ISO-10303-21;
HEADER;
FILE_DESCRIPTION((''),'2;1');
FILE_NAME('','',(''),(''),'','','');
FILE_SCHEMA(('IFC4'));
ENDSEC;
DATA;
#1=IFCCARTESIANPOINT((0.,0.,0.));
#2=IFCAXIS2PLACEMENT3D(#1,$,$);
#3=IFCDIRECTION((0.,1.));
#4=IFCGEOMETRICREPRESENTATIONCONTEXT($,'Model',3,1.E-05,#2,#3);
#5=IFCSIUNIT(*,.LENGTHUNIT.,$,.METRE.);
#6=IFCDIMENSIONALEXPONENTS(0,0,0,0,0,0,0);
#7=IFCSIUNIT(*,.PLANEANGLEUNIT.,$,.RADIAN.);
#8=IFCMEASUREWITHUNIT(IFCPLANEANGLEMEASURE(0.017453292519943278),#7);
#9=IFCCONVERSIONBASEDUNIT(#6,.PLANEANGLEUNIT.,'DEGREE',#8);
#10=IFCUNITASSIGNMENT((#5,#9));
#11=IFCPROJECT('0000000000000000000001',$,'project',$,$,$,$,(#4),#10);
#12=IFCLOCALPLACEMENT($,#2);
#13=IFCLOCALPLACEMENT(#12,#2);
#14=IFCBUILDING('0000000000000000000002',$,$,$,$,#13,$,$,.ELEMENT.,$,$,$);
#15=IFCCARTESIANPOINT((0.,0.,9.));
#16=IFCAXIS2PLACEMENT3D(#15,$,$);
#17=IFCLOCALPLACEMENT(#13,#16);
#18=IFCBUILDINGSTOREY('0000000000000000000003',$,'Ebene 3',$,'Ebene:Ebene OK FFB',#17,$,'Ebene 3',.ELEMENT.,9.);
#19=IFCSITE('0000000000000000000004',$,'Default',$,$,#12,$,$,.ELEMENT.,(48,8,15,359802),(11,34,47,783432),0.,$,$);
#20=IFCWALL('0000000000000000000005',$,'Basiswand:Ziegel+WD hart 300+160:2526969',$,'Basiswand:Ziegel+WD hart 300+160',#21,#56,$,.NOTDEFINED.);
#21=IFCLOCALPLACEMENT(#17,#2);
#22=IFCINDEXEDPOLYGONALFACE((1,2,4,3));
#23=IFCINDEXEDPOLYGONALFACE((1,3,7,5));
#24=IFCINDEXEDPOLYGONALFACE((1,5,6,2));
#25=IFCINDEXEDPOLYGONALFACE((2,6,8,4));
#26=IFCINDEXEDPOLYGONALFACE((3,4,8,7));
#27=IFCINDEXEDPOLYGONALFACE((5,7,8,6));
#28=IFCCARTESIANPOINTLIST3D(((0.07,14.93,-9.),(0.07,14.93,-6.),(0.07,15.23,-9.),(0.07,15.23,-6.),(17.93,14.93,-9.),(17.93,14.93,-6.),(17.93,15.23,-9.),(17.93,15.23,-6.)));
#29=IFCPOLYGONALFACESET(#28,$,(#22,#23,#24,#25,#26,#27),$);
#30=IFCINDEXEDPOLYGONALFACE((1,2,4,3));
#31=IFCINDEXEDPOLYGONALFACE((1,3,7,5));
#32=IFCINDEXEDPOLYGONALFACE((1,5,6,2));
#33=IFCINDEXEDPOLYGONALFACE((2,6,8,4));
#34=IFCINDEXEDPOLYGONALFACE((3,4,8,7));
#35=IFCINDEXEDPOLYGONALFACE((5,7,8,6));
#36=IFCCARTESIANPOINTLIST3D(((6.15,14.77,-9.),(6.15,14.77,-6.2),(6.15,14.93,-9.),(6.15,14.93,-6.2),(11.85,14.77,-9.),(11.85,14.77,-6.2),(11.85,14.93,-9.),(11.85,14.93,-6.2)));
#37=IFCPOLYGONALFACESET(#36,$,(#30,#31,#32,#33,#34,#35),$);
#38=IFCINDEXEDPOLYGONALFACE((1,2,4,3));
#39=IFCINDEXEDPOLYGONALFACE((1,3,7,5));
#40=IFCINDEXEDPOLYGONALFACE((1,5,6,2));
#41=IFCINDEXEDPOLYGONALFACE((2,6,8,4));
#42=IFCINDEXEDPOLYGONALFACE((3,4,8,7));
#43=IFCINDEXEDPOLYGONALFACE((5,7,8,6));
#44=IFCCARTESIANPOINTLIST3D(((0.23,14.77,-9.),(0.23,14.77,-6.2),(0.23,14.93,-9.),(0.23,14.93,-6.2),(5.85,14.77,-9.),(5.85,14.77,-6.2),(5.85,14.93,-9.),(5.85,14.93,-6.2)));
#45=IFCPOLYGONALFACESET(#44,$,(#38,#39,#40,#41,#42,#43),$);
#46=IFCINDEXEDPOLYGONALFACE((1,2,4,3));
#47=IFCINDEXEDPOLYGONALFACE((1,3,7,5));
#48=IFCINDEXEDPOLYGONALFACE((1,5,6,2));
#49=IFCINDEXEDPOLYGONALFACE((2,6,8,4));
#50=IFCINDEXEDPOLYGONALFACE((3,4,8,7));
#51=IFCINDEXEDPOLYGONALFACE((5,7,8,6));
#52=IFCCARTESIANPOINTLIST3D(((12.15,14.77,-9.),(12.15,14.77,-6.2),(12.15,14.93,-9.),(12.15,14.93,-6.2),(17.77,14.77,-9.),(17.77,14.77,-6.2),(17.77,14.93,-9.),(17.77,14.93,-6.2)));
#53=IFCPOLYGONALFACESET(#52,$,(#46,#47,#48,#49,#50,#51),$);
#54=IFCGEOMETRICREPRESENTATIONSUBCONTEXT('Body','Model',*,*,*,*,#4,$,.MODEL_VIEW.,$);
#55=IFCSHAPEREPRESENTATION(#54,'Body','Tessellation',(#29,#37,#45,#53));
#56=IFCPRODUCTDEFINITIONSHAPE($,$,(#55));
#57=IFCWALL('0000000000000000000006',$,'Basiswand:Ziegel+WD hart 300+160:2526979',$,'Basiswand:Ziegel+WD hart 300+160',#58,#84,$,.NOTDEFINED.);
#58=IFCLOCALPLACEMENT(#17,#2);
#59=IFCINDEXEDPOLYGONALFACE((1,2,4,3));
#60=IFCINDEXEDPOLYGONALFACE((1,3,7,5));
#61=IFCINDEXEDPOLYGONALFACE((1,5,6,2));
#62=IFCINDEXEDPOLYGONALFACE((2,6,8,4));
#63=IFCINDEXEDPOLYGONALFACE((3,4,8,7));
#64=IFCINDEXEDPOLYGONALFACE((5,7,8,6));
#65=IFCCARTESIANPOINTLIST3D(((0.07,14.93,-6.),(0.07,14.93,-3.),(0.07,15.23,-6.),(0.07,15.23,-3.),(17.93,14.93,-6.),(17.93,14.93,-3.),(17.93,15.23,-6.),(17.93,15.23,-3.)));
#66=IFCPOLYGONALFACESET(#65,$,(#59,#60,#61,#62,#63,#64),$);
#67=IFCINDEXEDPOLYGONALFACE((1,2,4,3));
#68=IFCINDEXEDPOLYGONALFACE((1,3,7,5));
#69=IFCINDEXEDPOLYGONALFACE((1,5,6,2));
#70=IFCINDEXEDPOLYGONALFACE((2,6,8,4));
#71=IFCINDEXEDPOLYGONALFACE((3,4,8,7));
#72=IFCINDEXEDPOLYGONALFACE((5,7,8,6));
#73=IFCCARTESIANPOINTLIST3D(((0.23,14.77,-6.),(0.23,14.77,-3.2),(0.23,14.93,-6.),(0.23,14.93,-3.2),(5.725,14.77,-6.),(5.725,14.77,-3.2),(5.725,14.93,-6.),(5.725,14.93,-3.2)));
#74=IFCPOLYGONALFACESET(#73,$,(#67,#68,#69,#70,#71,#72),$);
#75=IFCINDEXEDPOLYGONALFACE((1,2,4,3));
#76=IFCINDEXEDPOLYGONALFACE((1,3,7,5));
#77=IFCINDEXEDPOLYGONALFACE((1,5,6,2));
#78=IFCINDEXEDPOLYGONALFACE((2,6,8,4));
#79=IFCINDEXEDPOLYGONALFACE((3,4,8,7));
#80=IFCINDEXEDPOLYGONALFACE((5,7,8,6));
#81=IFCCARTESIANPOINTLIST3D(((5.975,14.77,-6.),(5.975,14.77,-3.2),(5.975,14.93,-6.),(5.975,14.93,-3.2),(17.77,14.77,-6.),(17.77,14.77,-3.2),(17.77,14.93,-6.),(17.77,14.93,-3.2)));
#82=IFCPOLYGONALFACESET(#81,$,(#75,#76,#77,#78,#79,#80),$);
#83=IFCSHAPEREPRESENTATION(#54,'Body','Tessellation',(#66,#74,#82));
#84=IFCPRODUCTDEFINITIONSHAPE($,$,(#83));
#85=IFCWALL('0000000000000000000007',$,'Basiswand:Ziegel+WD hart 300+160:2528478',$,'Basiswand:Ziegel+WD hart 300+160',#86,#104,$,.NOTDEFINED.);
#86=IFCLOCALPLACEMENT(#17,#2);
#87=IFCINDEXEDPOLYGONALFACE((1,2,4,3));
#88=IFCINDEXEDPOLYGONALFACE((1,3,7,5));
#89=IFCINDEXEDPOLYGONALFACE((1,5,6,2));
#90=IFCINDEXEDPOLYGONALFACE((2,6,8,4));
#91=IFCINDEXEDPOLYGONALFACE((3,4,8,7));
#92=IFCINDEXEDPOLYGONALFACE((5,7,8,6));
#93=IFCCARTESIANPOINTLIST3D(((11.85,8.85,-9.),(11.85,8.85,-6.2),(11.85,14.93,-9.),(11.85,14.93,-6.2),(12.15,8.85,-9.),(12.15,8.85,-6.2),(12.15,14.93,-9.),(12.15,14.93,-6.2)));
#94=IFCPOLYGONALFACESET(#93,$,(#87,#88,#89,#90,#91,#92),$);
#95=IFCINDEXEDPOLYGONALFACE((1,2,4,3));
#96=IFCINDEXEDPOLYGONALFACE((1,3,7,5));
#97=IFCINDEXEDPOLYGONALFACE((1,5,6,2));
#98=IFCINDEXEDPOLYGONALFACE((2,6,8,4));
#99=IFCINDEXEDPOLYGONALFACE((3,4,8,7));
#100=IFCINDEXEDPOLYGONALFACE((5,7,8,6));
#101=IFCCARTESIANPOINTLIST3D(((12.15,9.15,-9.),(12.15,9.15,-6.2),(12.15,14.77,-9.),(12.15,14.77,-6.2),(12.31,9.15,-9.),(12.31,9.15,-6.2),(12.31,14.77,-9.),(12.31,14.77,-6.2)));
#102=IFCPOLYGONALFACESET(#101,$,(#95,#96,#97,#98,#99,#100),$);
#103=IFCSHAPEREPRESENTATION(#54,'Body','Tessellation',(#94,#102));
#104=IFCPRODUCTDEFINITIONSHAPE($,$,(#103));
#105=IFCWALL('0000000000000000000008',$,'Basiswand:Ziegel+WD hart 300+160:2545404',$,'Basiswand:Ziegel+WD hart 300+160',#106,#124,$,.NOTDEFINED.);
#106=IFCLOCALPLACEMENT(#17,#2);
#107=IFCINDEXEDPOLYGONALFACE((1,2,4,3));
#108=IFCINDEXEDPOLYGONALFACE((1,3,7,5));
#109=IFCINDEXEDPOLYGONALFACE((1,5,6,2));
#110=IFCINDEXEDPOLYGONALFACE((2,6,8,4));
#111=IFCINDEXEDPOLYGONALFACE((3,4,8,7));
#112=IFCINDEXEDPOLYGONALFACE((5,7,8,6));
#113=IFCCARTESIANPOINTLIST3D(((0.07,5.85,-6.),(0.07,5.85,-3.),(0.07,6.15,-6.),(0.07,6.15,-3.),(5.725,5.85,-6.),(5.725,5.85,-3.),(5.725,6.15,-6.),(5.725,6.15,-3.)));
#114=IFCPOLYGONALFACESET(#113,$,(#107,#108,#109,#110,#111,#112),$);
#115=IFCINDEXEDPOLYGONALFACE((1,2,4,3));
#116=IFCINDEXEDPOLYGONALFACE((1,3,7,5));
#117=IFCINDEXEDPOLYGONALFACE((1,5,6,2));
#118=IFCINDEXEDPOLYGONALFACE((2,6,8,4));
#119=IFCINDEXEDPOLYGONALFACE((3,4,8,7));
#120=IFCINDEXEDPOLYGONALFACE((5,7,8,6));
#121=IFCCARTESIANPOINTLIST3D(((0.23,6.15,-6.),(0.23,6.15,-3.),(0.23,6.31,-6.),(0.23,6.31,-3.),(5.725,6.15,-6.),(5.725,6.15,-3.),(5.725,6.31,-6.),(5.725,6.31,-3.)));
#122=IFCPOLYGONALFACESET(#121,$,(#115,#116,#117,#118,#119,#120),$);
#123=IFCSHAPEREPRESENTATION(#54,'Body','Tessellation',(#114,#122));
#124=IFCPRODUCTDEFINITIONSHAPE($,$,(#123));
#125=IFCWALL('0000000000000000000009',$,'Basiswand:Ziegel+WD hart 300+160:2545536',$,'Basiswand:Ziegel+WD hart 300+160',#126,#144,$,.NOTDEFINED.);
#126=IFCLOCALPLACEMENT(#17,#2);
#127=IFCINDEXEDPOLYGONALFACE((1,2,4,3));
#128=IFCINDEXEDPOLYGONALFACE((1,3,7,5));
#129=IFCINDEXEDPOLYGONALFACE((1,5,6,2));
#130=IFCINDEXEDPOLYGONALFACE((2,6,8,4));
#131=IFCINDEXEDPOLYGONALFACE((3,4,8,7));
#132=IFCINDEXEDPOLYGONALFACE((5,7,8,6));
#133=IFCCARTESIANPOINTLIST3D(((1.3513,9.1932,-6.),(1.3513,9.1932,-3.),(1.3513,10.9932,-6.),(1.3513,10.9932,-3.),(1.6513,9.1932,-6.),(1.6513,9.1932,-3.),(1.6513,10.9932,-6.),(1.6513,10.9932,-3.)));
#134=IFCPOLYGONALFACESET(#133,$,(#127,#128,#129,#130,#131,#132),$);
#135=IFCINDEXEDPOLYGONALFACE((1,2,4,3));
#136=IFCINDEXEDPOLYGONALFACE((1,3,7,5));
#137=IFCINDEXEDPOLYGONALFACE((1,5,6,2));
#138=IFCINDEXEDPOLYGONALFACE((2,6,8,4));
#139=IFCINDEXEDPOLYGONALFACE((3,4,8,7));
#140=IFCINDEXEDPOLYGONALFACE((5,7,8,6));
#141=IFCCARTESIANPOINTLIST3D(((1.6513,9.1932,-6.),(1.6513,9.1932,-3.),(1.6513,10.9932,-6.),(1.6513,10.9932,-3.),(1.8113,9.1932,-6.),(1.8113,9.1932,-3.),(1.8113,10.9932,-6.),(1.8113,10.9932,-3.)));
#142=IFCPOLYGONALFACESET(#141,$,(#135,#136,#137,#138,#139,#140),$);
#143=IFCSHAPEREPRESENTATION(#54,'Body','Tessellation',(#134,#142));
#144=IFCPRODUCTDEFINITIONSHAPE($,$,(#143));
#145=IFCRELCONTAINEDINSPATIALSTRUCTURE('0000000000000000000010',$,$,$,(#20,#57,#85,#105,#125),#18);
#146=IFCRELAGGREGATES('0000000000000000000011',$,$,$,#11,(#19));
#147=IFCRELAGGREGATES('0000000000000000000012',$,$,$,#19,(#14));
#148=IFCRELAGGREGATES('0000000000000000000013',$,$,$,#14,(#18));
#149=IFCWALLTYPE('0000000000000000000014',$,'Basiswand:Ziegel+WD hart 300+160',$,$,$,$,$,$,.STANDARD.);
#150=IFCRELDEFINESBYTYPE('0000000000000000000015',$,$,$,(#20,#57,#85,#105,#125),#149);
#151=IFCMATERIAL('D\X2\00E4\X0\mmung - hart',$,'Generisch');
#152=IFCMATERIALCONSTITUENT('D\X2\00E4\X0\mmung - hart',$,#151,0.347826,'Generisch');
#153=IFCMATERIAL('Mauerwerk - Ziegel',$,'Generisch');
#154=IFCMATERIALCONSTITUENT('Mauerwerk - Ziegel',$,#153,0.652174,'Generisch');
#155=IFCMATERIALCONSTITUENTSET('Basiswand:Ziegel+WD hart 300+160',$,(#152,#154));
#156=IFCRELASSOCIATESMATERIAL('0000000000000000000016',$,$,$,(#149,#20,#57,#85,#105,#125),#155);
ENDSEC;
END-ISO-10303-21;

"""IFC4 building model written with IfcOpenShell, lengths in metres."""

from ifc_helpers import new_model, entity, si_unit, converted_unit, direction, frame, origin, place, context, subcontext, project, spatial, indexed_curve, outline, extrude, material, constituent, constituent_set, type_object, element, save


model = new_model("IFC4")

# Units and contexts
model_context = context("Model", 3, precision=1e-05, world=origin(), true_north=direction((0.0, 1.0)))
body_context = subcontext(model_context, "Body", "Model", "MODEL_VIEW")
ifc_project = project(units=[si_unit("LENGTHUNIT", "METRE"), converted_unit("PLANEANGLEUNIT", "DEGREE", entity("IfcPlaneAngleMeasure", 0.017453292519943278), si_unit("PLANEANGLEUNIT", "RADIAN"), dimensions=[0, 0, 0, 0, 0, 0, 0])], contexts=[model_context])

# Site, building, storey
site_placement = place(None, origin())
site = spatial("IfcSite", under=ifc_project, at=site_placement, Name="Default", CompositionType="ELEMENT", RefLatitude=(48, 8, 15, 359802), RefLongitude=(11, 34, 47, 783432), RefElevation=0.0)
building_placement = place(site_placement, origin())
building = spatial("IfcBuilding", under=site, at=building_placement, CompositionType="ELEMENT")
storey_placement = place(building_placement, frame((0.0, 0.0, 9.0)))
storey = spatial("IfcBuildingStorey", under=building, at=storey_placement, Name="Ebene 3", ObjectType="Ebene:Ebene OK FFB", LongName="Ebene 3", CompositionType="ELEMENT", Elevation=9.0)

# Walls
ifc_material_1 = material(Name="Dämmung - hart", Category="Generisch")
ifc_constituent_1 = constituent(ifc_material_1, Name="Dämmung - hart", Category="Generisch", fraction=0.347826)
ifc_material_2 = material(Name="Mauerwerk - Ziegel", Category="Generisch")
ifc_constituent_2 = constituent(ifc_material_2, Name="Mauerwerk - Ziegel", Category="Generisch", fraction=0.652174)
ifc_constituent_set_1 = constituent_set(constituents=[ifc_constituent_1, ifc_constituent_2], Name="Basiswand:Ziegel+WD hart 300+160")
wall_type_1 = type_object("IfcWallType", Name="Basiswand:Ziegel+WD hart 300+160", PredefinedType="STANDARD", material=ifc_constituent_set_1)
wall_1_placement = place(storey_placement, frame((17.77, 15.0, -9.0), z_axis=(0.0, 0.0, 1.0), x_axis=(-1.0, 0.0, 0.0)))
element("IfcWall", 1, at=wall_1_placement, inside=storey, type_object=wall_type_1, material=ifc_constituent_set_1, Name="Basiswand:Ziegel+WD hart 300+160:2526969", ObjectType="Basiswand:Ziegel+WD hart 300+160", PredefinedType="NOTDEFINED", context=body_context, shape_type="SweptSolid", body=[
    extrude(outline(indexed_curve([(-0.15, -8.93), (0.15, -8.93), (0.15, 8.93), (-0.15, 8.93), (-0.15, -8.93)], self_intersect=False)), frame((8.77, -0.08, 0.0), z_axis=(0.0, 0.0, 1.0), x_axis=(0.0, 1.0, 0.0)), (0.0, 0.0, 1.0), 3.0),
    extrude(outline(indexed_curve([(-2.85, -0.08), (2.85, -0.08), (2.85, 0.08), (-2.85, 0.08), (-2.85, -0.08)], self_intersect=False)), frame((8.77, 0.15, 0.0)), (0.0, 0.0, 1.0), 2.8),
    extrude(outline(indexed_curve([(-2.81, -0.08), (2.81, -0.08), (2.81, 0.08), (-2.81, 0.08), (-2.81, -0.08)], self_intersect=False)), frame((14.73, 0.15, 0.0), z_axis=(0.0, 0.0, 1.0), x_axis=(-1.0, 0.0, 0.0)), (0.0, 0.0, 1.0), 2.8),
    extrude(outline(indexed_curve([(-2.81, -0.08), (2.81, -0.08), (2.81, 0.08), (-2.81, 0.08), (-2.81, -0.08)], self_intersect=False)), frame((2.81, 0.15, 0.0)), (0.0, 0.0, 1.0), 2.8),
])
wall_2_placement = place(storey_placement, frame((17.77, 15.0, -6.0), z_axis=(0.0, 0.0, 1.0), x_axis=(-1.0, 0.0, 0.0)))
element("IfcWall", 2, at=wall_2_placement, inside=storey, type_object=wall_type_1, material=ifc_constituent_set_1, Name="Basiswand:Ziegel+WD hart 300+160:2526979", ObjectType="Basiswand:Ziegel+WD hart 300+160", PredefinedType="NOTDEFINED", context=body_context, shape_type="SweptSolid", body=[
    extrude(outline(indexed_curve([(-0.15, -8.93), (0.15, -8.93), (0.15, 8.93), (-0.15, 8.93), (-0.15, -8.93)], self_intersect=False)), frame((8.77, -0.08, 0.0), z_axis=(0.0, 0.0, 1.0), x_axis=(0.0, 1.0, 0.0)), (0.0, 0.0, 1.0), 3.0),
    extrude(outline(indexed_curve([(-2.7475, -0.08), (2.7475, -0.08), (2.7475, 0.08), (-2.7475, 0.08), (-2.7475, -0.08)], self_intersect=False)), frame((14.7925, 0.15, 0.0), z_axis=(0.0, 0.0, 1.0), x_axis=(-1.0, 0.0, 0.0)), (0.0, 0.0, 1.0), 2.8),
    extrude(outline(indexed_curve([(-5.8975, -0.08), (5.8975, -0.08), (5.8975, 0.08), (-5.8975, 0.08), (-5.8975, -0.08)], self_intersect=False)), frame((5.8975, 0.15, 0.0)), (0.0, 0.0, 1.0), 2.8),
])

# Wall
wall_3_placement = place(storey_placement, frame((12.08, 14.77, -9.0), z_axis=(0.0, 0.0, 1.0), x_axis=(0.0, -1.0, 0.0)))
element("IfcWall", 3, at=wall_3_placement, inside=storey, type_object=wall_type_1, material=ifc_constituent_set_1, Name="Basiswand:Ziegel+WD hart 300+160:2528478", ObjectType="Basiswand:Ziegel+WD hart 300+160", PredefinedType="NOTDEFINED", context=body_context, shape_type="SweptSolid", body=[
    extrude(outline(indexed_curve([(-1.4, -3.04), (1.4, -3.04), (1.4, 3.04), (-1.4, 3.04), (-1.4, -3.04)], self_intersect=False)), frame((2.88, -0.23, 1.4), z_axis=(0.0, 1.0, 0.0), x_axis=(0.0, 0.0, 1.0)), (0.0, 0.0, 1.0), 0.3),
    extrude(outline(indexed_curve([(-1.4, -2.81), (1.4, -2.81), (1.4, 2.81), (-1.4, 2.81), (-1.4, -2.81)], self_intersect=False)), frame((2.81, 0.07, 1.4), z_axis=(0.0, 1.0, 0.0), x_axis=(0.0, 0.0, 1.0)), (0.0, 0.0, 1.0), 0.16),
])

# Walls
wall_4_placement = place(storey_placement, frame((0.23, 6.08, -6.0)))
element("IfcWall", 4, at=wall_4_placement, inside=storey, type_object=wall_type_1, material=ifc_constituent_set_1, Name="Basiswand:Ziegel+WD hart 300+160:2545404", ObjectType="Basiswand:Ziegel+WD hart 300+160", PredefinedType="NOTDEFINED", context=body_context, shape_type="SweptSolid", body=[
    extrude(outline(indexed_curve([(-0.15, -2.8275), (0.15, -2.8275), (0.15, 2.8275), (-0.15, 2.8275), (-0.15, -2.8275)], self_intersect=False)), frame((2.6675, -0.08, 0.0), z_axis=(0.0, 0.0, 1.0), x_axis=(0.0, 1.0, 0.0)), (0.0, 0.0, 1.0), 3.0),
    extrude(outline(indexed_curve([(-0.08, -2.7475), (0.08, -2.7475), (0.08, 2.7475), (-0.08, 2.7475), (-0.08, -2.7475)], self_intersect=False)), frame((2.7475, 0.15, 0.0), z_axis=(0.0, 0.0, 1.0), x_axis=(0.0, 1.0, 0.0)), (0.0, 0.0, 1.0), 3.0),
])
wall_5_placement = place(storey_placement, frame((1.5813, 10.9932, -6.0), z_axis=(0.0, 0.0, 1.0), x_axis=(0.0, -1.0, 0.0)))
element("IfcWall", 5, at=wall_5_placement, inside=storey, type_object=wall_type_1, material=ifc_constituent_set_1, Name="Basiswand:Ziegel+WD hart 300+160:2545536", ObjectType="Basiswand:Ziegel+WD hart 300+160", PredefinedType="NOTDEFINED", context=body_context, shape_type="SweptSolid", body=[
    extrude(outline(indexed_curve([(-0.15, -0.9), (0.15, -0.9), (0.15, 0.9), (-0.15, 0.9), (-0.15, -0.9)], self_intersect=False)), frame((0.9, -0.08, 0.0), z_axis=(0.0, 0.0, 1.0), x_axis=(0.0, 1.0, 0.0)), (0.0, 0.0, 1.0), 3.0),
    extrude(outline(indexed_curve([(-0.08, -0.9), (0.08, -0.9), (0.08, 0.9), (-0.08, 0.9), (-0.08, -0.9)], self_intersect=False)), frame((0.9, 0.15, 0.0), z_axis=(0.0, 0.0, 1.0), x_axis=(0.0, -1.0, 0.0)), (0.0, 0.0, 1.0), 3.0),
])

save(model, "model.ifc")
